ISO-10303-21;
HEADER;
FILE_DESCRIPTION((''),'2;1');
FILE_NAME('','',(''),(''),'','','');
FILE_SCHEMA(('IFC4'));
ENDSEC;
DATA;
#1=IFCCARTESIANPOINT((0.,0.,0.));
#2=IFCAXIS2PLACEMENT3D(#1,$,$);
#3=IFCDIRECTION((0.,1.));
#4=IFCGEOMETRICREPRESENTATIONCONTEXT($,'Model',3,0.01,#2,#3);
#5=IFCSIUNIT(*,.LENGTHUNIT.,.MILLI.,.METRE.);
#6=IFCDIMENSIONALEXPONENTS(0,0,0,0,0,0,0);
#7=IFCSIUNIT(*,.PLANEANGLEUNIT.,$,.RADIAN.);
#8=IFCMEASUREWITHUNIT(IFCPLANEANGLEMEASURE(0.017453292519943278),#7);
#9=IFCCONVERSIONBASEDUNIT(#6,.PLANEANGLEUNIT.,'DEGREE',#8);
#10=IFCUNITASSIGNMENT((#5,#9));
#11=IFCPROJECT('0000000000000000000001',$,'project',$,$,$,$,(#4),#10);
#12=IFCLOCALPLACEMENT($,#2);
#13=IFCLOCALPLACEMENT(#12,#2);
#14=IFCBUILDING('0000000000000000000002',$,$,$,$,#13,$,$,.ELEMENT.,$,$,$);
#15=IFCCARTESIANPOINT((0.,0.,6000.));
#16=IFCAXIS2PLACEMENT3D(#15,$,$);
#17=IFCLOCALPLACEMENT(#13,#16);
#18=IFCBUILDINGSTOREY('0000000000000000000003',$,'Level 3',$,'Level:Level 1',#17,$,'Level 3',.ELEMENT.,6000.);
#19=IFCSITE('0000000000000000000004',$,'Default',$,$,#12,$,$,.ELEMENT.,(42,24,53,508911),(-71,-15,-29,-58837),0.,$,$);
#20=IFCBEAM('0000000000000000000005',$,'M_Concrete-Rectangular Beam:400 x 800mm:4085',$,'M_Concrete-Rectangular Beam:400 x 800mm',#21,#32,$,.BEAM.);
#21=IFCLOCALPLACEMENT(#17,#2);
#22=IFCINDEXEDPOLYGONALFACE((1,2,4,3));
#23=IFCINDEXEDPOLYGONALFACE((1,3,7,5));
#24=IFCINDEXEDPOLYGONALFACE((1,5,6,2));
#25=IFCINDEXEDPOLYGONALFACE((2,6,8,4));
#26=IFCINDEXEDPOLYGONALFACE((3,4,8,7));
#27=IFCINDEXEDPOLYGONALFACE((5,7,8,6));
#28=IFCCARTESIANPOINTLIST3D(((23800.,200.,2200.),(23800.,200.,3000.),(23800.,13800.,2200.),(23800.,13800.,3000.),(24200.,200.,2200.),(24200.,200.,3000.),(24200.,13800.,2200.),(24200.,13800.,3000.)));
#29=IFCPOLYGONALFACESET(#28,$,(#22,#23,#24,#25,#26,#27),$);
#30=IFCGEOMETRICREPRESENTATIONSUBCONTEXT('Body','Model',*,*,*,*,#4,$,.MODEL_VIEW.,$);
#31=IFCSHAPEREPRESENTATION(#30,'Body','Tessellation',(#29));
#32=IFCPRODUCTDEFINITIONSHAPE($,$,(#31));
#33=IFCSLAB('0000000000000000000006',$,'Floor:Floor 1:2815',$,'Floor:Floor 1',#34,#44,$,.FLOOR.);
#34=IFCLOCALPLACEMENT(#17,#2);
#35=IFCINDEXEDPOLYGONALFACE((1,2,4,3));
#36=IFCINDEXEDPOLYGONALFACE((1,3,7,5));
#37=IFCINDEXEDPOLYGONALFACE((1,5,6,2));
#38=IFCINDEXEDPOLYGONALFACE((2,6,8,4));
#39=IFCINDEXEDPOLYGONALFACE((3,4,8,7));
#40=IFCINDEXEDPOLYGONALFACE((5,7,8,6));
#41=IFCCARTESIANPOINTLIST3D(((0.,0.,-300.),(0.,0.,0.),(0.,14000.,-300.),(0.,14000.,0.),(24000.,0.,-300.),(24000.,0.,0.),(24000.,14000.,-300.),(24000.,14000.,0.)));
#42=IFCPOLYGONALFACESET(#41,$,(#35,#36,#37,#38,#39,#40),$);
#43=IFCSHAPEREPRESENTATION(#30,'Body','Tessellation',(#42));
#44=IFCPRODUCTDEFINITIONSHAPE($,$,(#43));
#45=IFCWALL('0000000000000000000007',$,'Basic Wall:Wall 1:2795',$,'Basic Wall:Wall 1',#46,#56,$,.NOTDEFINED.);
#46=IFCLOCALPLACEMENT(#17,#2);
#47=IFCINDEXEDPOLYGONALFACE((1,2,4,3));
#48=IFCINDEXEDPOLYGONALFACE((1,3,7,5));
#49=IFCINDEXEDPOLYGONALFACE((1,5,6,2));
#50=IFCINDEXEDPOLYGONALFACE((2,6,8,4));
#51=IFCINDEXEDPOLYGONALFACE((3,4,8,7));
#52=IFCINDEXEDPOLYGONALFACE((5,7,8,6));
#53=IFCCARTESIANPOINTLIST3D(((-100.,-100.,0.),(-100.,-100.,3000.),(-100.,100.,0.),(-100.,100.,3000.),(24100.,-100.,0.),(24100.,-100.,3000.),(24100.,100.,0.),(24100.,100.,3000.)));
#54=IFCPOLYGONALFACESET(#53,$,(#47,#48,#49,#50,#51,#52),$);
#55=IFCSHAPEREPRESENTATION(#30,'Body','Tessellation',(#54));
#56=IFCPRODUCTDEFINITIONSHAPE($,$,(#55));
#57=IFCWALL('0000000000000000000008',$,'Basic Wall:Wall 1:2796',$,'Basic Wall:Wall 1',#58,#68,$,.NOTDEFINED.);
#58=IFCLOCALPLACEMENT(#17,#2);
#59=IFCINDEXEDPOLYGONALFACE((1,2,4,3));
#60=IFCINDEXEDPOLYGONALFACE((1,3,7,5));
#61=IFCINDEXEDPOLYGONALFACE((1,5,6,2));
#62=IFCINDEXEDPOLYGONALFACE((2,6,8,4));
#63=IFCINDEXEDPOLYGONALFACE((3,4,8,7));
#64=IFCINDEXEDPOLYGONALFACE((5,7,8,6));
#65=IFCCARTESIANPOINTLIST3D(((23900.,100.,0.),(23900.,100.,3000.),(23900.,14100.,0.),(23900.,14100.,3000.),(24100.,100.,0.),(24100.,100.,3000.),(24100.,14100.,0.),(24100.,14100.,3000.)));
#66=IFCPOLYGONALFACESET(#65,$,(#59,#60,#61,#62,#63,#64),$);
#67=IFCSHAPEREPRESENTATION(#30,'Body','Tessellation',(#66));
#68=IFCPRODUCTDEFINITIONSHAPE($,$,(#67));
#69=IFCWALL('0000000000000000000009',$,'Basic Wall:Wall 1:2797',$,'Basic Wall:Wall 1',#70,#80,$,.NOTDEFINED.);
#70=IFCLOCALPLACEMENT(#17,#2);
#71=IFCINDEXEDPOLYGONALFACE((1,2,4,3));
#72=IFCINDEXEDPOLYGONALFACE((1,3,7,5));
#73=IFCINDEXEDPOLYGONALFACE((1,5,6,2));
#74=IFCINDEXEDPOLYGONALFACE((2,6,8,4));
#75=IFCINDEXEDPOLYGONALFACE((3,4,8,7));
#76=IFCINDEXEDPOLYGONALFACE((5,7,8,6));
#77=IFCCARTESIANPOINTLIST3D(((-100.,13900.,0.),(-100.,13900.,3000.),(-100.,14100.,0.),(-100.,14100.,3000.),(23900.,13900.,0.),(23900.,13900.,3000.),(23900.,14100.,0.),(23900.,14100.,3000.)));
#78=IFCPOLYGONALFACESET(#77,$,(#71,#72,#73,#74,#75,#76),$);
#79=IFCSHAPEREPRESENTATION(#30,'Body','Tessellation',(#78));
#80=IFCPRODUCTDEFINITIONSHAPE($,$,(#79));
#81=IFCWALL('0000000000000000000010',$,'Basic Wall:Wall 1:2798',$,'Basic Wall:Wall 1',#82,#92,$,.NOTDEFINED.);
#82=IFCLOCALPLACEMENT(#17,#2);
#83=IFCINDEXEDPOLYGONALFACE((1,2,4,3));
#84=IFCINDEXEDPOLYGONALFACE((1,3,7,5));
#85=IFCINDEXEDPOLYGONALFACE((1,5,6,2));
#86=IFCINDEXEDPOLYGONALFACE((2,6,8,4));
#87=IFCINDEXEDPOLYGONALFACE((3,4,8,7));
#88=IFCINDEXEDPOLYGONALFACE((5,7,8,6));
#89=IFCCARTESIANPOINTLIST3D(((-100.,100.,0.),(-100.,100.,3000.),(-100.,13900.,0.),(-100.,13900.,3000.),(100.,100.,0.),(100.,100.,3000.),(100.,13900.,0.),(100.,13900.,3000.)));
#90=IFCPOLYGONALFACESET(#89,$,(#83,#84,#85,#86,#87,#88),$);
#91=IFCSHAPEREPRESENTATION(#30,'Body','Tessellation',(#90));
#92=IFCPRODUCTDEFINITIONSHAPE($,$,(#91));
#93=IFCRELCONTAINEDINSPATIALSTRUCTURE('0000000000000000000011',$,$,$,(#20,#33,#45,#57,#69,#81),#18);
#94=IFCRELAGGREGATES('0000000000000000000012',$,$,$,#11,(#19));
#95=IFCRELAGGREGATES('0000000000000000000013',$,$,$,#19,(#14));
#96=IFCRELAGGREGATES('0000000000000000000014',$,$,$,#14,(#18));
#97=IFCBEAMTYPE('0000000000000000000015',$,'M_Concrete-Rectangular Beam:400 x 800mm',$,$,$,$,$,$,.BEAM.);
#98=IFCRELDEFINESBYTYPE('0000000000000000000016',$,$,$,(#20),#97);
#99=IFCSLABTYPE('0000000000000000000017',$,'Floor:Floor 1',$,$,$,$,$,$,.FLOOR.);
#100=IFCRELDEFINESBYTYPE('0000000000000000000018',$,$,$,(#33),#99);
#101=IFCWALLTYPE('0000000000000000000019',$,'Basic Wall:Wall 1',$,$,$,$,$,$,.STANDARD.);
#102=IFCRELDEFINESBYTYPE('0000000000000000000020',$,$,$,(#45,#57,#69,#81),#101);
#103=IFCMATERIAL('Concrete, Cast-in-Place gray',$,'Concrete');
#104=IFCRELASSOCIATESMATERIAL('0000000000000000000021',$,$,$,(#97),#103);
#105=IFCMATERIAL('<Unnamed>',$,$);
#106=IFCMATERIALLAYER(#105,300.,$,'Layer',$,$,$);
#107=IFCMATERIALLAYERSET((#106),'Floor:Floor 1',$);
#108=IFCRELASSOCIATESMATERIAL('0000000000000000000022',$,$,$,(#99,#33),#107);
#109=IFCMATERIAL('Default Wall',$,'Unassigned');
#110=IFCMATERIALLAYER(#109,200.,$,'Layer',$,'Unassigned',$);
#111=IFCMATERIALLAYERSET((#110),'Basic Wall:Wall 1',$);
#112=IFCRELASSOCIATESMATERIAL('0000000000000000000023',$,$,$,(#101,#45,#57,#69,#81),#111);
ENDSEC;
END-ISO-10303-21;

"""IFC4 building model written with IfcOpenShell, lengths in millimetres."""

from ifc_helpers import new_model, entity, si_unit, converted_unit, direction, frame, frame_2d, origin, origin_2d_with_axis, place, context, subcontext, project, spatial, rectangle, extrude, source, transform, mapped, material, layer, layer_set, layer_usage, material_profile, profile_set, type_object, type_shapes, element, save


model = new_model("IFC4")

# Units and contexts
model_context = context("Model", 3, precision=0.01, world=origin(), true_north=direction((0.0, 1.0)))
body_context = subcontext(model_context, "Body", "Model", "MODEL_VIEW")
ifc_project = project(units=[si_unit("LENGTHUNIT", "METRE", prefix="MILLI"), converted_unit("PLANEANGLEUNIT", "DEGREE", entity("IfcPlaneAngleMeasure", 0.017453292519943278), si_unit("PLANEANGLEUNIT", "RADIAN"), dimensions=[0, 0, 0, 0, 0, 0, 0])], contexts=[model_context])

# Site, building, storey
site_placement = place(None, origin())
site = spatial("IfcSite", under=ifc_project, at=site_placement, Name="Default", CompositionType="ELEMENT", RefLatitude=(42, 24, 53, 508911), RefLongitude=(-71, -15, -29, -58837), RefElevation=0.0)
building_placement = place(site_placement, origin())
building = spatial("IfcBuilding", under=site, at=building_placement, CompositionType="ELEMENT")
storey_placement = place(building_placement, frame((0.0, 0.0, 6000.0)))
storey = spatial("IfcBuildingStorey", under=building, at=storey_placement, Name="Level 3", ObjectType="Level:Level 1", LongName="Level 3", CompositionType="ELEMENT", Elevation=6000.0)

# Beam
ifc_material_1 = material(Name="Concrete, Cast-in-Place gray", Category="Concrete")
ifc_material_profile = material_profile(ifc_material_1, rectangle(XDim=800.0, YDim=400.0, at=origin_2d_with_axis()), Name="400 x 800mm")
ifc_profile_set = profile_set([ifc_material_profile], Name="400 x 800mm")
beam_type_1 = type_object("IfcBeamType", Name="M_Concrete-Rectangular Beam:400 x 800mm", PredefinedType="BEAM", material=ifc_profile_set)
shared_shape_1 = source(origin(), body_context, "Body", "SweptSolid", [
    extrude(rectangle(XDim=800.0, YDim=400.0, at=frame_2d((0.0, 0.0), x_axis=(0.0, 1.0))), frame((24000.0, 200.0, 8600.0), z_axis=(0.0, 1.0, 0.0), x_axis=(-1.0, 0.0, 0.0)), (0.0, 0.0, 1.0), 13600.0),
])
type_shapes(beam_type_1, [shared_shape_1])
beam_1_placement = place(storey_placement, frame((0.0, 0.0, -6000.0)))
element("IfcBeam", 1, at=beam_1_placement, inside=storey, type_object=beam_type_1, Name="M_Concrete-Rectangular Beam:400 x 800mm:4085", ObjectType="M_Concrete-Rectangular Beam:400 x 800mm", PredefinedType="BEAM", context=body_context, shape_type="MappedRepresentation", body=[
    mapped(shared_shape_1, transform((0.0, 0.0, 0.0), scale=1.0)),
])

# Slab
ifc_material_2 = material(Name="<Unnamed>")
ifc_layer_1 = layer(ifc_material_2, 300.0, Name="Layer")
ifc_layer_set_1 = layer_set([ifc_layer_1], Name="Floor:Floor 1")
ifc_layer_usage_1 = layer_usage(ifc_layer_set_1, "AXIS3", "POSITIVE", 0.0)
slab_type = type_object("IfcSlabType", Name="Floor:Floor 1", PredefinedType="FLOOR", material=ifc_layer_set_1)
slab_placement = place(storey_placement, origin())
element("IfcSlab", 2, at=slab_placement, inside=storey, type_object=slab_type, material=ifc_layer_usage_1, Name="Floor:Floor 1:2815", ObjectType="Floor:Floor 1", PredefinedType="FLOOR", context=body_context, shape_type="SweptSolid", body=[
    extrude(rectangle(XDim=14000.0, YDim=24000.0, at=origin_2d_with_axis()), frame((12000.0, 7000.0, 0.0), z_axis=(0.0, 0.0, -1.0), x_axis=(0.0, 1.0, 0.0)), (0.0, 0.0, 1.0), 300.0),
])

# Walls
ifc_material_3 = material(Name="Default Wall", Category="Unassigned")
ifc_layer_2 = layer(ifc_material_3, 200.0, Name="Layer", Category="Unassigned")
ifc_layer_set_2 = layer_set([ifc_layer_2], Name="Basic Wall:Wall 1")
ifc_layer_usage_2 = layer_usage(ifc_layer_set_2, "AXIS2", "NEGATIVE", 100.0)
wall_type = type_object("IfcWallType", Name="Basic Wall:Wall 1", PredefinedType="STANDARD", material=ifc_layer_set_2)
wall_1_placement = place(storey_placement, frame((-100.0, 0.0, 0.0)))
element("IfcWall", 3, at=wall_1_placement, inside=storey, type_object=wall_type, material=ifc_layer_usage_2, Name="Basic Wall:Wall 1:2795", ObjectType="Basic Wall:Wall 1", PredefinedType="NOTDEFINED", context=body_context, shape_type="SweptSolid", body=[
    extrude(rectangle(XDim=24200.0, YDim=200.0, at=frame_2d((12100.0, 0.0), x_axis=(-1.0, 0.0))), origin(), (0.0, 0.0, 1.0), 3000.0),
])
ifc_layer_usage_3 = layer_usage(ifc_layer_set_2, "AXIS2", "NEGATIVE", 100.0)
wall_2_placement = place(storey_placement, frame((24000.0, 100.0, 0.0), z_axis=(0.0, 0.0, 1.0), x_axis=(0.0, 1.0, 0.0)))
element("IfcWall", 4, at=wall_2_placement, inside=storey, type_object=wall_type, material=ifc_layer_usage_3, Name="Basic Wall:Wall 1:2796", ObjectType="Basic Wall:Wall 1", PredefinedType="NOTDEFINED", context=body_context, shape_type="SweptSolid", body=[
    extrude(rectangle(XDim=14000.0, YDim=200.0, at=frame_2d((7000.0, 0.0), x_axis=(-1.0, 0.0))), origin(), (0.0, 0.0, 1.0), 3000.0),
])
ifc_layer_usage_4 = layer_usage(ifc_layer_set_2, "AXIS2", "NEGATIVE", 100.0)
wall_3_placement = place(storey_placement, frame((23900.0, 14000.0, 0.0), z_axis=(0.0, 0.0, 1.0), x_axis=(-1.0, 0.0, 0.0)))
element("IfcWall", 5, at=wall_3_placement, inside=storey, type_object=wall_type, material=ifc_layer_usage_4, Name="Basic Wall:Wall 1:2797", ObjectType="Basic Wall:Wall 1", PredefinedType="NOTDEFINED", context=body_context, shape_type="SweptSolid", body=[
    extrude(rectangle(XDim=24000.0, YDim=200.0, at=frame_2d((12000.0, 0.0), x_axis=(-1.0, 0.0))), origin(), (0.0, 0.0, 1.0), 3000.0),
])
ifc_layer_usage_5 = layer_usage(ifc_layer_set_2, "AXIS2", "NEGATIVE", 100.0)
wall_4_placement = place(storey_placement, frame((0.0, 13900.0, 0.0), z_axis=(0.0, 0.0, 1.0), x_axis=(0.0, -1.0, 0.0)))
element("IfcWall", 6, at=wall_4_placement, inside=storey, type_object=wall_type, material=ifc_layer_usage_5, Name="Basic Wall:Wall 1:2798", ObjectType="Basic Wall:Wall 1", PredefinedType="NOTDEFINED", context=body_context, shape_type="SweptSolid", body=[
    extrude(rectangle(XDim=13800.0, YDim=200.0, at=frame_2d((6900.0, 0.0), x_axis=(-1.0, 0.0))), origin(), (0.0, 0.0, 1.0), 3000.0),
])

save(model, "model.ifc")
